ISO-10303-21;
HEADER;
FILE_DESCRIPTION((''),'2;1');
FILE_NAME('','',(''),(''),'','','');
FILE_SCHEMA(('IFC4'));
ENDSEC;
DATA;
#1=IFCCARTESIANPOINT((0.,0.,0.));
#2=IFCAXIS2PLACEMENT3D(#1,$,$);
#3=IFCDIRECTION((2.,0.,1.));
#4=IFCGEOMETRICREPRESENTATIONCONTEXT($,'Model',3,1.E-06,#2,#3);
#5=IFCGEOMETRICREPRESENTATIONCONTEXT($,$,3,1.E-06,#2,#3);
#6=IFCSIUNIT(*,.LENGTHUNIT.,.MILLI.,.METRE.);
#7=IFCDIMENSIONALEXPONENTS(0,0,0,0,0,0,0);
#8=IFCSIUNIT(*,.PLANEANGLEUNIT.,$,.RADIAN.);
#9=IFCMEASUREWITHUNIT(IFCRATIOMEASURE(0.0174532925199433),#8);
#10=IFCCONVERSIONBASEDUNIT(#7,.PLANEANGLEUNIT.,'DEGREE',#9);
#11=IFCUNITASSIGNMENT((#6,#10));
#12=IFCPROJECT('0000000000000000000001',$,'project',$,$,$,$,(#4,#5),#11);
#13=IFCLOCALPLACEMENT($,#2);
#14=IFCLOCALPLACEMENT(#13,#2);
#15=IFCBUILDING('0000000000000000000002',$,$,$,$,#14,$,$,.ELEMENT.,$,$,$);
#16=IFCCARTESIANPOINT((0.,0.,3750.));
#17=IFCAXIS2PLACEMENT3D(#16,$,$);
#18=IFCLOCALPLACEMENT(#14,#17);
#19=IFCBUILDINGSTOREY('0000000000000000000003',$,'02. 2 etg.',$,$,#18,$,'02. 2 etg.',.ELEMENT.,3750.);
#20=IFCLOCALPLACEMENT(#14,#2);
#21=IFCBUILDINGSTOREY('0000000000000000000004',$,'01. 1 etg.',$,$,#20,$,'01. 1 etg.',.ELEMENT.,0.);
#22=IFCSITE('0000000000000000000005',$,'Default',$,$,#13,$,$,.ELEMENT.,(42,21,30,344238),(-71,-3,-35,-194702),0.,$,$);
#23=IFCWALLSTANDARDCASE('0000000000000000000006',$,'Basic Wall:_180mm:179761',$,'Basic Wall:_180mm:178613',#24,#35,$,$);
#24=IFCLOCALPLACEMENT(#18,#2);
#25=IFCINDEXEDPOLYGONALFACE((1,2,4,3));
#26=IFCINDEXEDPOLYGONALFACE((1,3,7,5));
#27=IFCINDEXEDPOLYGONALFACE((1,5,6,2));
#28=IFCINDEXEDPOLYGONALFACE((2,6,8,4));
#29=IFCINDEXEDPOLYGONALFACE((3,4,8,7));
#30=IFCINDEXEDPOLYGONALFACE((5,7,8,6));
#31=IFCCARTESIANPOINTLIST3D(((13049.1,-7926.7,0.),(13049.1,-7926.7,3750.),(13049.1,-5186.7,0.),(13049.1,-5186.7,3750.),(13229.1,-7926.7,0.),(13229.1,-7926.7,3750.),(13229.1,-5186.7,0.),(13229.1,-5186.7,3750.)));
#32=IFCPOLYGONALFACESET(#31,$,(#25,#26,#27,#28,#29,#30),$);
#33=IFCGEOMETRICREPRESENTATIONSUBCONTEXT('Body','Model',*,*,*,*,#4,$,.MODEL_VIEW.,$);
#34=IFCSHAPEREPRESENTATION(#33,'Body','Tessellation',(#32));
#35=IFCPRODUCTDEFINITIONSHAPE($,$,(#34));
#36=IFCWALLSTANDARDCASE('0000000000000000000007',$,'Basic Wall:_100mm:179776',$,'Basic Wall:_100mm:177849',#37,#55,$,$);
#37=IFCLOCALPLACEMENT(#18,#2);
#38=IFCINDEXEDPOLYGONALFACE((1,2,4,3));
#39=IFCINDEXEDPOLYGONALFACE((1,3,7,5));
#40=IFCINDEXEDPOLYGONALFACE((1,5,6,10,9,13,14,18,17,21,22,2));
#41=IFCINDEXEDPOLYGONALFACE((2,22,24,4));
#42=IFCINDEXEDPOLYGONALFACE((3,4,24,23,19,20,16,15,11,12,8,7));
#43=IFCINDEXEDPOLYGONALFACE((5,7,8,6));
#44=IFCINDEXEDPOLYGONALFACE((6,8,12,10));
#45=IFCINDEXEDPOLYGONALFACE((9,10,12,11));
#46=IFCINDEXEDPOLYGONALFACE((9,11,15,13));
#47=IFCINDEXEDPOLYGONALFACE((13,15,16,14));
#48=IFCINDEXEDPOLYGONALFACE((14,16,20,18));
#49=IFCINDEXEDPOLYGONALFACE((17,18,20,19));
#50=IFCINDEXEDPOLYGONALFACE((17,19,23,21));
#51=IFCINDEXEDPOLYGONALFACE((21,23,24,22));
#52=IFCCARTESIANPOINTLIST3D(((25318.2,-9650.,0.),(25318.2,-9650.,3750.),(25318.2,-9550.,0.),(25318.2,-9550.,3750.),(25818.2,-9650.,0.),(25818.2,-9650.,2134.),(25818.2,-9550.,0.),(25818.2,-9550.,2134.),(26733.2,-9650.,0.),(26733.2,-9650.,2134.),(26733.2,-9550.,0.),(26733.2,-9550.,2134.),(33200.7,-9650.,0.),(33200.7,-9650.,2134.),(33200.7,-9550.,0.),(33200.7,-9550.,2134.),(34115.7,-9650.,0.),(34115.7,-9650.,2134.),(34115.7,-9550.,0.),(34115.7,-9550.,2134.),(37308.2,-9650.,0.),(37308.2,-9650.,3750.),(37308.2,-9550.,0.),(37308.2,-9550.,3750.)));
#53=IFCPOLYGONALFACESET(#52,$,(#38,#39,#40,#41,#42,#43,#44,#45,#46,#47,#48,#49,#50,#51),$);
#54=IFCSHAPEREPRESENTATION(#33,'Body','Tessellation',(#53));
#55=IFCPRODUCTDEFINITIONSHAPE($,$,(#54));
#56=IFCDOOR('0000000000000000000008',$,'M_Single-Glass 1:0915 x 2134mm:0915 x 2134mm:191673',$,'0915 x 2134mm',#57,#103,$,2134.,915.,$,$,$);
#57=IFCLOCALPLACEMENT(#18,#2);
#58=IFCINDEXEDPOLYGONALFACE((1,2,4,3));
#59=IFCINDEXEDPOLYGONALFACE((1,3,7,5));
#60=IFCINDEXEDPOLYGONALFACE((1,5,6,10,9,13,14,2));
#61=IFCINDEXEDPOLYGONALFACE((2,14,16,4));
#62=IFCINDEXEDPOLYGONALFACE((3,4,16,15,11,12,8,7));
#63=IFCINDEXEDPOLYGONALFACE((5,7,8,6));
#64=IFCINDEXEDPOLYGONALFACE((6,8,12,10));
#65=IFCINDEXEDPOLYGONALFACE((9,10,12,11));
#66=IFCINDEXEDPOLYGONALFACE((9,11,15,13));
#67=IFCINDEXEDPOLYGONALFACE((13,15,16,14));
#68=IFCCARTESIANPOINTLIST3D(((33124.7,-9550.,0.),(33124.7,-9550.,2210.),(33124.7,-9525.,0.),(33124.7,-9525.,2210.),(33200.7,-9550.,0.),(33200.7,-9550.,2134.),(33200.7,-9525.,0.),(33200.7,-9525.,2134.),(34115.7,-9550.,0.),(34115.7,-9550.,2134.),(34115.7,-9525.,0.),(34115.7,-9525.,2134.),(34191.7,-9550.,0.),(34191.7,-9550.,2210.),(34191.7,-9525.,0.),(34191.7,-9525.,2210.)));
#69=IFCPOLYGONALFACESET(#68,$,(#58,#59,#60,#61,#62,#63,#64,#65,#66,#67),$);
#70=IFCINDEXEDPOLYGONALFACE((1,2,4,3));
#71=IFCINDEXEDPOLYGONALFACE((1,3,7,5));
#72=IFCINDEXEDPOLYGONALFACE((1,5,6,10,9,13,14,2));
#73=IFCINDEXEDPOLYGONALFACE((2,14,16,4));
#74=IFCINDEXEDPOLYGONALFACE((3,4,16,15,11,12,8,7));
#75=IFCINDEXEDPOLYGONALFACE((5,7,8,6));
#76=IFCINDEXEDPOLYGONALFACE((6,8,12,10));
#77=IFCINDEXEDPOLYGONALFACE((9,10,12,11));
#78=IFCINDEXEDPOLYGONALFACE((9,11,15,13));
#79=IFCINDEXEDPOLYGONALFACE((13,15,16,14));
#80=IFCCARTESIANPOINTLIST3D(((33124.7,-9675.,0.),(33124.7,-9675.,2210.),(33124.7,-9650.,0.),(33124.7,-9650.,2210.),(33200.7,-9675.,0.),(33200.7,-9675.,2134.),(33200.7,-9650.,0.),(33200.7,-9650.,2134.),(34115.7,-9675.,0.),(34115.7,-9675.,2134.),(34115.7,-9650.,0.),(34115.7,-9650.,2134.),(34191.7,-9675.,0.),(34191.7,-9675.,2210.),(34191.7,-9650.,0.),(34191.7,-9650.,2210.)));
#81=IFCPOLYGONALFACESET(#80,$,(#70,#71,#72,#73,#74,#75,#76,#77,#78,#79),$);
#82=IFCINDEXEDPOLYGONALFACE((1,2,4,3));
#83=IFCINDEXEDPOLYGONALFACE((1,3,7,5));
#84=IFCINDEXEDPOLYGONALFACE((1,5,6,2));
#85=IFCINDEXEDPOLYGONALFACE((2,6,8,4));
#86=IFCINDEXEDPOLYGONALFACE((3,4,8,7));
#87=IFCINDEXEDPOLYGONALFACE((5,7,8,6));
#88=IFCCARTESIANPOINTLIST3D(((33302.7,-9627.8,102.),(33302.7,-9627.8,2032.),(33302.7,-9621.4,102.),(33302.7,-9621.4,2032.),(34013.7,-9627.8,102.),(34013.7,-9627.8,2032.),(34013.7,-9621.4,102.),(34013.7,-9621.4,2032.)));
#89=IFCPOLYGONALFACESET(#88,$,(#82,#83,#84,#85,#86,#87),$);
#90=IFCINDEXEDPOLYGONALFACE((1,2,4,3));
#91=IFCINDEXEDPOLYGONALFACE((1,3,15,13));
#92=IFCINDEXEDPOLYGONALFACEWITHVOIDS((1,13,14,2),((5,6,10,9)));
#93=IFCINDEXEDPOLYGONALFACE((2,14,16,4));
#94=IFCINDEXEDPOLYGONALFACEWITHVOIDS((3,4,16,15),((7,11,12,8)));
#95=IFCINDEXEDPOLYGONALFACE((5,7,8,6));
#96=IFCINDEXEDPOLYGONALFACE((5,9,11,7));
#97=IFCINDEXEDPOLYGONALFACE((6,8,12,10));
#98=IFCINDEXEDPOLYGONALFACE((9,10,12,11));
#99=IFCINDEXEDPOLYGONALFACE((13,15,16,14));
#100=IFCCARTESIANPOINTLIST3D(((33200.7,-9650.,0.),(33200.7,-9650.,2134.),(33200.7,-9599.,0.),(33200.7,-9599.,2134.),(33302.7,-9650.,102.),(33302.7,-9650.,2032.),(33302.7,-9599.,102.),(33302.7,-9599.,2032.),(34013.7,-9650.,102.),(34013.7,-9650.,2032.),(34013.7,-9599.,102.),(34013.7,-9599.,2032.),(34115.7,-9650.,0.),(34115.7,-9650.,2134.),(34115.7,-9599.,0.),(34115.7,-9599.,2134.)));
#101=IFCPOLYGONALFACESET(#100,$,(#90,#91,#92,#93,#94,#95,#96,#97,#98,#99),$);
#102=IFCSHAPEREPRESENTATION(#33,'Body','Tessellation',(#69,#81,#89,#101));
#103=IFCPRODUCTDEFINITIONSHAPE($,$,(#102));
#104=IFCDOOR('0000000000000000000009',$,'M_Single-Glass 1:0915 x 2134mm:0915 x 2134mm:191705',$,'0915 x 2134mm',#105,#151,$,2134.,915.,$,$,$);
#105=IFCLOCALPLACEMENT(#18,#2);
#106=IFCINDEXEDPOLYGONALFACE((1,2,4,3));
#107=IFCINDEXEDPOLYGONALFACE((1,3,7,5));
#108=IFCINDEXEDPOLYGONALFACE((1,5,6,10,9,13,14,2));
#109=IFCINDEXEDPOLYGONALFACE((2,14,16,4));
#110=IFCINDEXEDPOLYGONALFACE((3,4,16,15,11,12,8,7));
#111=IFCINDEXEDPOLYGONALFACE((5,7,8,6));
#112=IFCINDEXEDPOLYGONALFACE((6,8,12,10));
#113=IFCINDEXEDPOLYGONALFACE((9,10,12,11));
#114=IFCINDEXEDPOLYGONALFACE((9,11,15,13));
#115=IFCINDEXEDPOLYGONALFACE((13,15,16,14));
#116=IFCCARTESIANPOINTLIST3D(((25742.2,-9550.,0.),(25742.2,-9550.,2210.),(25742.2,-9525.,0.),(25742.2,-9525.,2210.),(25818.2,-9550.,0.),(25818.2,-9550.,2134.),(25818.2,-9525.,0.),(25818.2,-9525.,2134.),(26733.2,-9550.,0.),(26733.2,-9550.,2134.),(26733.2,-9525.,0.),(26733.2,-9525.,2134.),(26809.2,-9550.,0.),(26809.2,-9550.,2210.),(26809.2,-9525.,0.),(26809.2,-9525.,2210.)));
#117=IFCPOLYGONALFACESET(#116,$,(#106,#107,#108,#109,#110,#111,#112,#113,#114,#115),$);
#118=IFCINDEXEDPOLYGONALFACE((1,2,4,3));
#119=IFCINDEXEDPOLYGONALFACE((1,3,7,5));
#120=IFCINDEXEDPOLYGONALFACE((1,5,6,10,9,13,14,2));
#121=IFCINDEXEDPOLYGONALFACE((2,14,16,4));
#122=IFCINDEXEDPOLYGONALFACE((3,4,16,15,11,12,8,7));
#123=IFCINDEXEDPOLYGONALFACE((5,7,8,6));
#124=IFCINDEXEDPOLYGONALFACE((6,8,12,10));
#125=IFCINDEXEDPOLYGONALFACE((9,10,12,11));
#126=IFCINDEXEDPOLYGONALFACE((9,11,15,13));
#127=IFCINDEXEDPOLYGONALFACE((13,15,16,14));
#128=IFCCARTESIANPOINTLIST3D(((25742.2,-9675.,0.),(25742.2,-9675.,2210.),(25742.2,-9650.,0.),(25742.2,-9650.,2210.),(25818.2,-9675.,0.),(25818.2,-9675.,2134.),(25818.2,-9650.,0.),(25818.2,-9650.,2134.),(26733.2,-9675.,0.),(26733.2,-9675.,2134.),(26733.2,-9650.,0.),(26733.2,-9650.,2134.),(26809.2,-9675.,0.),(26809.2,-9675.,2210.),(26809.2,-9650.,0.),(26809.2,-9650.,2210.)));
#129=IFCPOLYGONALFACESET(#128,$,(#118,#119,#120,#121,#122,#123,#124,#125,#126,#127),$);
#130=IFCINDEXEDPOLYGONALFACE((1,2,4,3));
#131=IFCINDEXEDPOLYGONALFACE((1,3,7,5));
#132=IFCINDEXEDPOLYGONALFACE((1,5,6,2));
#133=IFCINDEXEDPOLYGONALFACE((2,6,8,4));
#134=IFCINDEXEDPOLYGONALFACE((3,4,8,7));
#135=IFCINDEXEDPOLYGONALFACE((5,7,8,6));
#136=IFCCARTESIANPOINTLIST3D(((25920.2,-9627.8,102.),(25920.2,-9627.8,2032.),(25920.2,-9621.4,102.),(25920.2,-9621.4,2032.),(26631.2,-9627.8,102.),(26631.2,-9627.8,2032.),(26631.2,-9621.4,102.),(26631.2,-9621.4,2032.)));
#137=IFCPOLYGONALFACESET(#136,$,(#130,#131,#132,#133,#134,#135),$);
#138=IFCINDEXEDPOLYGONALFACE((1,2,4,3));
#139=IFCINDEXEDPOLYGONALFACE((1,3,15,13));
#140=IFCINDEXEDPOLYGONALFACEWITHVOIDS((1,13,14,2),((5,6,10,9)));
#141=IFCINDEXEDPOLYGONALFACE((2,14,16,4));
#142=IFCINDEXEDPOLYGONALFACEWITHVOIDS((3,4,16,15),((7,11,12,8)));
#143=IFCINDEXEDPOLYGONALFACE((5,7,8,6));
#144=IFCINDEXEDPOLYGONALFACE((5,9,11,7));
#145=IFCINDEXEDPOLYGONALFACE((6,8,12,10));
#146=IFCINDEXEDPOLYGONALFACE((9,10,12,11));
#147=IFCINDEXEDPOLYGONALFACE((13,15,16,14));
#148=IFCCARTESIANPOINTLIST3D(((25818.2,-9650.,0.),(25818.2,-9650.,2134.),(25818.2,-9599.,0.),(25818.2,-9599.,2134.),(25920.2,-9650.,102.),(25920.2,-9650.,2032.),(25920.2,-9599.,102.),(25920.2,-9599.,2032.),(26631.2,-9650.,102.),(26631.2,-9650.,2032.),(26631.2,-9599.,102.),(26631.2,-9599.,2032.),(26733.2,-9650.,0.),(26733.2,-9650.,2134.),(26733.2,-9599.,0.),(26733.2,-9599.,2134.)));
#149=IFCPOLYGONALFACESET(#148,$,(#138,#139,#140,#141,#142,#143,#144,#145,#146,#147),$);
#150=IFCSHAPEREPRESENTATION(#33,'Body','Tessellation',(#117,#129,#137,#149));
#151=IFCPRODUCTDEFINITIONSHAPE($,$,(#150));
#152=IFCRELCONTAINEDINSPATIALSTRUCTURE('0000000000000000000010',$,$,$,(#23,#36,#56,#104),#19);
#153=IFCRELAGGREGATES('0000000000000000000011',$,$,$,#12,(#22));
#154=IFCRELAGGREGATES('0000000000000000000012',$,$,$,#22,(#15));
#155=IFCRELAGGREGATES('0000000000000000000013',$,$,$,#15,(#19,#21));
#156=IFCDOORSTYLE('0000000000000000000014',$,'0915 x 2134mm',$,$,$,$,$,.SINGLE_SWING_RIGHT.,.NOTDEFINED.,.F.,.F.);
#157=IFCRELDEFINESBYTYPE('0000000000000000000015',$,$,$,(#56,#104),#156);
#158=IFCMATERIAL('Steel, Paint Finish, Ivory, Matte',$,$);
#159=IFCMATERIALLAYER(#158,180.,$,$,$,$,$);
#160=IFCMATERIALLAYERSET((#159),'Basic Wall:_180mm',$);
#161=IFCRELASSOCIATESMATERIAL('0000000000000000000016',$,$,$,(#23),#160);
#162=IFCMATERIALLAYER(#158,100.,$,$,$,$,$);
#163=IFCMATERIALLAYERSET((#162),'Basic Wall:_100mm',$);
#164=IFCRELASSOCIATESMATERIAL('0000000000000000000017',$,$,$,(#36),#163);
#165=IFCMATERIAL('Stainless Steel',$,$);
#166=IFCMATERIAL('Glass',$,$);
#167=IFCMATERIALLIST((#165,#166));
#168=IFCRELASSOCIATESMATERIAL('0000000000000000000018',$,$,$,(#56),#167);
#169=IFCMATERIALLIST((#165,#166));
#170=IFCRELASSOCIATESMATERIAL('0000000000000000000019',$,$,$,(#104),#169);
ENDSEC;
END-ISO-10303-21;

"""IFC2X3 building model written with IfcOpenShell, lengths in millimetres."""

from ifc_helpers import new_model, entity, si_unit, converted_unit, direction, frame, frame_2d, origin, place, context, subcontext, project, spatial, polyline, rectangle, outline, extrude, source, transform, mapped, material, material_list, layer, layer_set, layer_usage, type_object, type_shapes, element, fill, save


model = new_model("IFC2X3")

# Units and contexts
model_context = context("Model", 3, precision=1e-06, world=origin(), true_north=direction((2.0, 0.0, 1.0)))
context_of_model = context(None, 3, precision=1e-06, world=origin(), true_north=direction((2.0, 0.0, 1.0)))
body_context = subcontext(model_context, "Body", "Model", "MODEL_VIEW")
ifc_project = project(units=[si_unit("LENGTHUNIT", "METRE", prefix="MILLI"), converted_unit("PLANEANGLEUNIT", "DEGREE", entity("IfcRatioMeasure", 0.0174532925199433), si_unit("PLANEANGLEUNIT", "RADIAN"), dimensions=[0, 0, 0, 0, 0, 0, 0])], contexts=[model_context, context_of_model])

# Site, building, storey
site_placement = place(None, origin())
site = spatial("IfcSite", under=ifc_project, at=site_placement, Name="Default", CompositionType="ELEMENT", RefLatitude=(42, 21, 30, 344238), RefLongitude=(-71, -3, -35, -194702), RefElevation=0.0)
building_placement = place(site_placement, origin())
building = spatial("IfcBuilding", under=site, at=building_placement, CompositionType="ELEMENT")
storey_1_placement = place(building_placement, frame((0.0, 0.0, 3750.0)))
storey_1 = spatial("IfcBuildingStorey", under=building, at=storey_1_placement, Name="02. 2 etg.", LongName="02. 2 etg.", CompositionType="ELEMENT", Elevation=3750.0)

# Shared definitions
ifc_material_1 = material(Name="Steel, Paint Finish, Ivory, Matte")
ifc_layer_1 = layer(ifc_material_1, 100.0)
ifc_layer_set_1 = layer_set([ifc_layer_1], Name="Basic Wall:_100mm")
ifc_material_2 = material(Name="Stainless Steel")
ifc_material_3 = material(Name="Glass")

# Shared definitions
ifc_layer_2 = layer(ifc_material_1, 180.0)
ifc_layer_set_2 = layer_set([ifc_layer_2], Name="Basic Wall:_180mm")

# Wall
ifc_layer_usage_1 = layer_usage(ifc_layer_set_2, "AXIS2", "NEGATIVE", 90.0)
wall_1_placement = place(storey_1_placement, frame((13139.1, -5186.7, 0.0), z_axis=(0.0, 0.0, 1.0), x_axis=(0.0, -1.0, 0.0)))
element("IfcWallStandardCase", 1, at=wall_1_placement, inside=storey_1, material=ifc_layer_usage_1, Name="Basic Wall:_180mm:179761", ObjectType="Basic Wall:_180mm:178613", context=body_context, shape_type="SweptSolid", body=[
    extrude(rectangle(XDim=2740.0, YDim=180.0, at=frame_2d((1370.0, 0.0), x_axis=(-1.0, 0.0))), origin(), (0.0, 0.0, 1.0), 3750.0),
])

# Wall, openings, doors
ifc_layer_usage_2 = layer_usage(ifc_layer_set_1, "AXIS2", "POSITIVE", -50.0)
wall_2_placement = place(storey_1_placement, frame((25318.2, -9600.0, 0.0)))
wall_2 = element("IfcWallStandardCase", 2, at=wall_2_placement, inside=storey_1, material=ifc_layer_usage_2, Name="Basic Wall:_100mm:179776", ObjectType="Basic Wall:_100mm:177849", context=body_context, shape_type="SweptSolid", body=[
    extrude(rectangle(XDim=11990.0, YDim=100.0, at=frame_2d((5995.0, 0.0), x_axis=(-1.0, 0.0))), origin(), (0.0, 0.0, 1.0), 3750.0),
])
opening_1_placement = place(wall_2_placement, frame((8797.5, 50.0, 0.0)))
opening_1 = element("IfcOpeningElement", 3, at=opening_1_placement, cuts=wall_2, ObjectType="Opening", context=body_context, shape_type="SweptSolid", body=[
    extrude(rectangle(XDim=915.0, YDim=2134.0, at=frame_2d((1067.0, 457.5), x_axis=(0.0, 1.0))), frame((0.0, 0.0, 0.0), z_axis=(0.0, -1.0, 0.0), x_axis=(0.0, 0.0, 1.0)), (0.0, 0.0, 1.0), 100.0),
])
opening_2_placement = place(wall_2_placement, frame((1415.0, 50.0, 0.0)))
opening_2 = element("IfcOpeningElement", 4, at=opening_2_placement, cuts=wall_2, ObjectType="Opening", context=body_context, shape_type="SweptSolid", body=[
    extrude(rectangle(XDim=915.0, YDim=2134.0, at=frame_2d((1067.0, 457.5), x_axis=(0.0, 1.0))), frame((0.0, 0.0, 0.0), z_axis=(0.0, -1.0, 0.0), x_axis=(0.0, 0.0, 1.0)), (0.0, 0.0, 1.0), 100.0),
])
ifc_material_list_1 = material_list([ifc_material_2, ifc_material_3])
door_style_1 = type_object("IfcDoorStyle", Name="0915 x 2134mm", ConstructionType="NOTDEFINED", OperationType="SINGLE_SWING_RIGHT", ParameterTakesPrecedence=False, Sizeable=False)
shared_shape_1 = source(origin(), body_context, "Body", "SweptSolid", [
    extrude(outline(polyline([(-457.5, -1048.0), (-457.5, 1086.0), (-533.5, 1086.0), (-533.5, -1124.0), (533.5, -1124.0), (533.5, 1086.0), (457.5, 1086.0), (457.5, -1048.0), (-457.5, -1048.0)])), frame((457.5, -25.0, 1086.0), z_axis=(0.0, -1.0, 0.0), x_axis=(-1.0, 0.0, 0.0)), (0.0, 0.0, -1.0), 25.0),
    extrude(outline(polyline([(-457.5, -1048.0), (-457.5, 1086.0), (-533.5, 1086.0), (-533.5, -1124.0), (533.5, -1124.0), (533.5, 1086.0), (457.5, 1086.0), (457.5, -1048.0), (-457.5, -1048.0)])), frame((457.5, 100.0, 1086.0), z_axis=(0.0, -1.0, 0.0), x_axis=(-1.0, 0.0, 0.0)), (0.0, 0.0, -1.0), 25.0),
    extrude(rectangle(XDim=6.3, YDim=711.0, at=frame_2d((0.0, 0.0), x_axis=(1.0, 0.0))), frame((457.5, 74.6, 102.0), z_axis=(0.0, 0.0, 1.0), x_axis=(0.0, 1.0, 0.0)), (0.0, 0.0, 1.0), 1930.0),
    extrude(outline(polyline([(-1067.0, -457.5), (1067.0, -457.5), (1067.0, 457.5), (-1067.0, 457.5), (-1067.0, -457.5)]), holes=[polyline([(-965.0, 355.5), (965.0, 355.5), (965.0, -355.5), (-965.0, -355.5), (-965.0, 355.5)])]), frame((457.5, 49.0, 1067.0), z_axis=(0.0, 1.0, 0.0), x_axis=(0.0, 0.0, -1.0)), (0.0, 0.0, 1.0), 51.0),
])
type_shapes(door_style_1, [shared_shape_1])
door_1_placement = place(opening_1_placement, frame((0.0, 0.0, 0.0), z_axis=(0.0, 0.0, 1.0), x_axis=(-1.0, 0.0, 0.0)))
door_1 = element("IfcDoor", 5, at=door_1_placement, inside=storey_1, type_object=door_style_1, material=ifc_material_list_1, Name="M_Single-Glass 1:0915 x 2134mm:0915 x 2134mm:191673", ObjectType="0915 x 2134mm", OverallHeight=2134.0, OverallWidth=915.0, context=body_context, shape_type="MappedRepresentation", body=[
    mapped(shared_shape_1, transform((0.0, 0.0, 0.0), scale=1.0)),
])
fill(opening_1, door_1)
ifc_material_list_2 = material_list([ifc_material_2, ifc_material_3])
door_2_placement = place(opening_2_placement, frame((0.0, 0.0, 0.0), z_axis=(0.0, 0.0, 1.0), x_axis=(-1.0, 0.0, 0.0)))
door_2 = element("IfcDoor", 6, at=door_2_placement, inside=storey_1, type_object=door_style_1, material=ifc_material_list_2, Name="M_Single-Glass 1:0915 x 2134mm:0915 x 2134mm:191705", ObjectType="0915 x 2134mm", OverallHeight=2134.0, OverallWidth=915.0, context=body_context, shape_type="MappedRepresentation", body=[
    mapped(shared_shape_1, transform((0.0, 0.0, 0.0), scale=1.0)),
])
fill(opening_2, door_2)

# Shared definitions
storey_2_placement = place(building_placement, origin())
storey_2 = spatial("IfcBuildingStorey", under=building, at=storey_2_placement, Name="01. 1 etg.", LongName="01. 1 etg.", CompositionType="ELEMENT", Elevation=0.0)

save(model, "model.ifc")
